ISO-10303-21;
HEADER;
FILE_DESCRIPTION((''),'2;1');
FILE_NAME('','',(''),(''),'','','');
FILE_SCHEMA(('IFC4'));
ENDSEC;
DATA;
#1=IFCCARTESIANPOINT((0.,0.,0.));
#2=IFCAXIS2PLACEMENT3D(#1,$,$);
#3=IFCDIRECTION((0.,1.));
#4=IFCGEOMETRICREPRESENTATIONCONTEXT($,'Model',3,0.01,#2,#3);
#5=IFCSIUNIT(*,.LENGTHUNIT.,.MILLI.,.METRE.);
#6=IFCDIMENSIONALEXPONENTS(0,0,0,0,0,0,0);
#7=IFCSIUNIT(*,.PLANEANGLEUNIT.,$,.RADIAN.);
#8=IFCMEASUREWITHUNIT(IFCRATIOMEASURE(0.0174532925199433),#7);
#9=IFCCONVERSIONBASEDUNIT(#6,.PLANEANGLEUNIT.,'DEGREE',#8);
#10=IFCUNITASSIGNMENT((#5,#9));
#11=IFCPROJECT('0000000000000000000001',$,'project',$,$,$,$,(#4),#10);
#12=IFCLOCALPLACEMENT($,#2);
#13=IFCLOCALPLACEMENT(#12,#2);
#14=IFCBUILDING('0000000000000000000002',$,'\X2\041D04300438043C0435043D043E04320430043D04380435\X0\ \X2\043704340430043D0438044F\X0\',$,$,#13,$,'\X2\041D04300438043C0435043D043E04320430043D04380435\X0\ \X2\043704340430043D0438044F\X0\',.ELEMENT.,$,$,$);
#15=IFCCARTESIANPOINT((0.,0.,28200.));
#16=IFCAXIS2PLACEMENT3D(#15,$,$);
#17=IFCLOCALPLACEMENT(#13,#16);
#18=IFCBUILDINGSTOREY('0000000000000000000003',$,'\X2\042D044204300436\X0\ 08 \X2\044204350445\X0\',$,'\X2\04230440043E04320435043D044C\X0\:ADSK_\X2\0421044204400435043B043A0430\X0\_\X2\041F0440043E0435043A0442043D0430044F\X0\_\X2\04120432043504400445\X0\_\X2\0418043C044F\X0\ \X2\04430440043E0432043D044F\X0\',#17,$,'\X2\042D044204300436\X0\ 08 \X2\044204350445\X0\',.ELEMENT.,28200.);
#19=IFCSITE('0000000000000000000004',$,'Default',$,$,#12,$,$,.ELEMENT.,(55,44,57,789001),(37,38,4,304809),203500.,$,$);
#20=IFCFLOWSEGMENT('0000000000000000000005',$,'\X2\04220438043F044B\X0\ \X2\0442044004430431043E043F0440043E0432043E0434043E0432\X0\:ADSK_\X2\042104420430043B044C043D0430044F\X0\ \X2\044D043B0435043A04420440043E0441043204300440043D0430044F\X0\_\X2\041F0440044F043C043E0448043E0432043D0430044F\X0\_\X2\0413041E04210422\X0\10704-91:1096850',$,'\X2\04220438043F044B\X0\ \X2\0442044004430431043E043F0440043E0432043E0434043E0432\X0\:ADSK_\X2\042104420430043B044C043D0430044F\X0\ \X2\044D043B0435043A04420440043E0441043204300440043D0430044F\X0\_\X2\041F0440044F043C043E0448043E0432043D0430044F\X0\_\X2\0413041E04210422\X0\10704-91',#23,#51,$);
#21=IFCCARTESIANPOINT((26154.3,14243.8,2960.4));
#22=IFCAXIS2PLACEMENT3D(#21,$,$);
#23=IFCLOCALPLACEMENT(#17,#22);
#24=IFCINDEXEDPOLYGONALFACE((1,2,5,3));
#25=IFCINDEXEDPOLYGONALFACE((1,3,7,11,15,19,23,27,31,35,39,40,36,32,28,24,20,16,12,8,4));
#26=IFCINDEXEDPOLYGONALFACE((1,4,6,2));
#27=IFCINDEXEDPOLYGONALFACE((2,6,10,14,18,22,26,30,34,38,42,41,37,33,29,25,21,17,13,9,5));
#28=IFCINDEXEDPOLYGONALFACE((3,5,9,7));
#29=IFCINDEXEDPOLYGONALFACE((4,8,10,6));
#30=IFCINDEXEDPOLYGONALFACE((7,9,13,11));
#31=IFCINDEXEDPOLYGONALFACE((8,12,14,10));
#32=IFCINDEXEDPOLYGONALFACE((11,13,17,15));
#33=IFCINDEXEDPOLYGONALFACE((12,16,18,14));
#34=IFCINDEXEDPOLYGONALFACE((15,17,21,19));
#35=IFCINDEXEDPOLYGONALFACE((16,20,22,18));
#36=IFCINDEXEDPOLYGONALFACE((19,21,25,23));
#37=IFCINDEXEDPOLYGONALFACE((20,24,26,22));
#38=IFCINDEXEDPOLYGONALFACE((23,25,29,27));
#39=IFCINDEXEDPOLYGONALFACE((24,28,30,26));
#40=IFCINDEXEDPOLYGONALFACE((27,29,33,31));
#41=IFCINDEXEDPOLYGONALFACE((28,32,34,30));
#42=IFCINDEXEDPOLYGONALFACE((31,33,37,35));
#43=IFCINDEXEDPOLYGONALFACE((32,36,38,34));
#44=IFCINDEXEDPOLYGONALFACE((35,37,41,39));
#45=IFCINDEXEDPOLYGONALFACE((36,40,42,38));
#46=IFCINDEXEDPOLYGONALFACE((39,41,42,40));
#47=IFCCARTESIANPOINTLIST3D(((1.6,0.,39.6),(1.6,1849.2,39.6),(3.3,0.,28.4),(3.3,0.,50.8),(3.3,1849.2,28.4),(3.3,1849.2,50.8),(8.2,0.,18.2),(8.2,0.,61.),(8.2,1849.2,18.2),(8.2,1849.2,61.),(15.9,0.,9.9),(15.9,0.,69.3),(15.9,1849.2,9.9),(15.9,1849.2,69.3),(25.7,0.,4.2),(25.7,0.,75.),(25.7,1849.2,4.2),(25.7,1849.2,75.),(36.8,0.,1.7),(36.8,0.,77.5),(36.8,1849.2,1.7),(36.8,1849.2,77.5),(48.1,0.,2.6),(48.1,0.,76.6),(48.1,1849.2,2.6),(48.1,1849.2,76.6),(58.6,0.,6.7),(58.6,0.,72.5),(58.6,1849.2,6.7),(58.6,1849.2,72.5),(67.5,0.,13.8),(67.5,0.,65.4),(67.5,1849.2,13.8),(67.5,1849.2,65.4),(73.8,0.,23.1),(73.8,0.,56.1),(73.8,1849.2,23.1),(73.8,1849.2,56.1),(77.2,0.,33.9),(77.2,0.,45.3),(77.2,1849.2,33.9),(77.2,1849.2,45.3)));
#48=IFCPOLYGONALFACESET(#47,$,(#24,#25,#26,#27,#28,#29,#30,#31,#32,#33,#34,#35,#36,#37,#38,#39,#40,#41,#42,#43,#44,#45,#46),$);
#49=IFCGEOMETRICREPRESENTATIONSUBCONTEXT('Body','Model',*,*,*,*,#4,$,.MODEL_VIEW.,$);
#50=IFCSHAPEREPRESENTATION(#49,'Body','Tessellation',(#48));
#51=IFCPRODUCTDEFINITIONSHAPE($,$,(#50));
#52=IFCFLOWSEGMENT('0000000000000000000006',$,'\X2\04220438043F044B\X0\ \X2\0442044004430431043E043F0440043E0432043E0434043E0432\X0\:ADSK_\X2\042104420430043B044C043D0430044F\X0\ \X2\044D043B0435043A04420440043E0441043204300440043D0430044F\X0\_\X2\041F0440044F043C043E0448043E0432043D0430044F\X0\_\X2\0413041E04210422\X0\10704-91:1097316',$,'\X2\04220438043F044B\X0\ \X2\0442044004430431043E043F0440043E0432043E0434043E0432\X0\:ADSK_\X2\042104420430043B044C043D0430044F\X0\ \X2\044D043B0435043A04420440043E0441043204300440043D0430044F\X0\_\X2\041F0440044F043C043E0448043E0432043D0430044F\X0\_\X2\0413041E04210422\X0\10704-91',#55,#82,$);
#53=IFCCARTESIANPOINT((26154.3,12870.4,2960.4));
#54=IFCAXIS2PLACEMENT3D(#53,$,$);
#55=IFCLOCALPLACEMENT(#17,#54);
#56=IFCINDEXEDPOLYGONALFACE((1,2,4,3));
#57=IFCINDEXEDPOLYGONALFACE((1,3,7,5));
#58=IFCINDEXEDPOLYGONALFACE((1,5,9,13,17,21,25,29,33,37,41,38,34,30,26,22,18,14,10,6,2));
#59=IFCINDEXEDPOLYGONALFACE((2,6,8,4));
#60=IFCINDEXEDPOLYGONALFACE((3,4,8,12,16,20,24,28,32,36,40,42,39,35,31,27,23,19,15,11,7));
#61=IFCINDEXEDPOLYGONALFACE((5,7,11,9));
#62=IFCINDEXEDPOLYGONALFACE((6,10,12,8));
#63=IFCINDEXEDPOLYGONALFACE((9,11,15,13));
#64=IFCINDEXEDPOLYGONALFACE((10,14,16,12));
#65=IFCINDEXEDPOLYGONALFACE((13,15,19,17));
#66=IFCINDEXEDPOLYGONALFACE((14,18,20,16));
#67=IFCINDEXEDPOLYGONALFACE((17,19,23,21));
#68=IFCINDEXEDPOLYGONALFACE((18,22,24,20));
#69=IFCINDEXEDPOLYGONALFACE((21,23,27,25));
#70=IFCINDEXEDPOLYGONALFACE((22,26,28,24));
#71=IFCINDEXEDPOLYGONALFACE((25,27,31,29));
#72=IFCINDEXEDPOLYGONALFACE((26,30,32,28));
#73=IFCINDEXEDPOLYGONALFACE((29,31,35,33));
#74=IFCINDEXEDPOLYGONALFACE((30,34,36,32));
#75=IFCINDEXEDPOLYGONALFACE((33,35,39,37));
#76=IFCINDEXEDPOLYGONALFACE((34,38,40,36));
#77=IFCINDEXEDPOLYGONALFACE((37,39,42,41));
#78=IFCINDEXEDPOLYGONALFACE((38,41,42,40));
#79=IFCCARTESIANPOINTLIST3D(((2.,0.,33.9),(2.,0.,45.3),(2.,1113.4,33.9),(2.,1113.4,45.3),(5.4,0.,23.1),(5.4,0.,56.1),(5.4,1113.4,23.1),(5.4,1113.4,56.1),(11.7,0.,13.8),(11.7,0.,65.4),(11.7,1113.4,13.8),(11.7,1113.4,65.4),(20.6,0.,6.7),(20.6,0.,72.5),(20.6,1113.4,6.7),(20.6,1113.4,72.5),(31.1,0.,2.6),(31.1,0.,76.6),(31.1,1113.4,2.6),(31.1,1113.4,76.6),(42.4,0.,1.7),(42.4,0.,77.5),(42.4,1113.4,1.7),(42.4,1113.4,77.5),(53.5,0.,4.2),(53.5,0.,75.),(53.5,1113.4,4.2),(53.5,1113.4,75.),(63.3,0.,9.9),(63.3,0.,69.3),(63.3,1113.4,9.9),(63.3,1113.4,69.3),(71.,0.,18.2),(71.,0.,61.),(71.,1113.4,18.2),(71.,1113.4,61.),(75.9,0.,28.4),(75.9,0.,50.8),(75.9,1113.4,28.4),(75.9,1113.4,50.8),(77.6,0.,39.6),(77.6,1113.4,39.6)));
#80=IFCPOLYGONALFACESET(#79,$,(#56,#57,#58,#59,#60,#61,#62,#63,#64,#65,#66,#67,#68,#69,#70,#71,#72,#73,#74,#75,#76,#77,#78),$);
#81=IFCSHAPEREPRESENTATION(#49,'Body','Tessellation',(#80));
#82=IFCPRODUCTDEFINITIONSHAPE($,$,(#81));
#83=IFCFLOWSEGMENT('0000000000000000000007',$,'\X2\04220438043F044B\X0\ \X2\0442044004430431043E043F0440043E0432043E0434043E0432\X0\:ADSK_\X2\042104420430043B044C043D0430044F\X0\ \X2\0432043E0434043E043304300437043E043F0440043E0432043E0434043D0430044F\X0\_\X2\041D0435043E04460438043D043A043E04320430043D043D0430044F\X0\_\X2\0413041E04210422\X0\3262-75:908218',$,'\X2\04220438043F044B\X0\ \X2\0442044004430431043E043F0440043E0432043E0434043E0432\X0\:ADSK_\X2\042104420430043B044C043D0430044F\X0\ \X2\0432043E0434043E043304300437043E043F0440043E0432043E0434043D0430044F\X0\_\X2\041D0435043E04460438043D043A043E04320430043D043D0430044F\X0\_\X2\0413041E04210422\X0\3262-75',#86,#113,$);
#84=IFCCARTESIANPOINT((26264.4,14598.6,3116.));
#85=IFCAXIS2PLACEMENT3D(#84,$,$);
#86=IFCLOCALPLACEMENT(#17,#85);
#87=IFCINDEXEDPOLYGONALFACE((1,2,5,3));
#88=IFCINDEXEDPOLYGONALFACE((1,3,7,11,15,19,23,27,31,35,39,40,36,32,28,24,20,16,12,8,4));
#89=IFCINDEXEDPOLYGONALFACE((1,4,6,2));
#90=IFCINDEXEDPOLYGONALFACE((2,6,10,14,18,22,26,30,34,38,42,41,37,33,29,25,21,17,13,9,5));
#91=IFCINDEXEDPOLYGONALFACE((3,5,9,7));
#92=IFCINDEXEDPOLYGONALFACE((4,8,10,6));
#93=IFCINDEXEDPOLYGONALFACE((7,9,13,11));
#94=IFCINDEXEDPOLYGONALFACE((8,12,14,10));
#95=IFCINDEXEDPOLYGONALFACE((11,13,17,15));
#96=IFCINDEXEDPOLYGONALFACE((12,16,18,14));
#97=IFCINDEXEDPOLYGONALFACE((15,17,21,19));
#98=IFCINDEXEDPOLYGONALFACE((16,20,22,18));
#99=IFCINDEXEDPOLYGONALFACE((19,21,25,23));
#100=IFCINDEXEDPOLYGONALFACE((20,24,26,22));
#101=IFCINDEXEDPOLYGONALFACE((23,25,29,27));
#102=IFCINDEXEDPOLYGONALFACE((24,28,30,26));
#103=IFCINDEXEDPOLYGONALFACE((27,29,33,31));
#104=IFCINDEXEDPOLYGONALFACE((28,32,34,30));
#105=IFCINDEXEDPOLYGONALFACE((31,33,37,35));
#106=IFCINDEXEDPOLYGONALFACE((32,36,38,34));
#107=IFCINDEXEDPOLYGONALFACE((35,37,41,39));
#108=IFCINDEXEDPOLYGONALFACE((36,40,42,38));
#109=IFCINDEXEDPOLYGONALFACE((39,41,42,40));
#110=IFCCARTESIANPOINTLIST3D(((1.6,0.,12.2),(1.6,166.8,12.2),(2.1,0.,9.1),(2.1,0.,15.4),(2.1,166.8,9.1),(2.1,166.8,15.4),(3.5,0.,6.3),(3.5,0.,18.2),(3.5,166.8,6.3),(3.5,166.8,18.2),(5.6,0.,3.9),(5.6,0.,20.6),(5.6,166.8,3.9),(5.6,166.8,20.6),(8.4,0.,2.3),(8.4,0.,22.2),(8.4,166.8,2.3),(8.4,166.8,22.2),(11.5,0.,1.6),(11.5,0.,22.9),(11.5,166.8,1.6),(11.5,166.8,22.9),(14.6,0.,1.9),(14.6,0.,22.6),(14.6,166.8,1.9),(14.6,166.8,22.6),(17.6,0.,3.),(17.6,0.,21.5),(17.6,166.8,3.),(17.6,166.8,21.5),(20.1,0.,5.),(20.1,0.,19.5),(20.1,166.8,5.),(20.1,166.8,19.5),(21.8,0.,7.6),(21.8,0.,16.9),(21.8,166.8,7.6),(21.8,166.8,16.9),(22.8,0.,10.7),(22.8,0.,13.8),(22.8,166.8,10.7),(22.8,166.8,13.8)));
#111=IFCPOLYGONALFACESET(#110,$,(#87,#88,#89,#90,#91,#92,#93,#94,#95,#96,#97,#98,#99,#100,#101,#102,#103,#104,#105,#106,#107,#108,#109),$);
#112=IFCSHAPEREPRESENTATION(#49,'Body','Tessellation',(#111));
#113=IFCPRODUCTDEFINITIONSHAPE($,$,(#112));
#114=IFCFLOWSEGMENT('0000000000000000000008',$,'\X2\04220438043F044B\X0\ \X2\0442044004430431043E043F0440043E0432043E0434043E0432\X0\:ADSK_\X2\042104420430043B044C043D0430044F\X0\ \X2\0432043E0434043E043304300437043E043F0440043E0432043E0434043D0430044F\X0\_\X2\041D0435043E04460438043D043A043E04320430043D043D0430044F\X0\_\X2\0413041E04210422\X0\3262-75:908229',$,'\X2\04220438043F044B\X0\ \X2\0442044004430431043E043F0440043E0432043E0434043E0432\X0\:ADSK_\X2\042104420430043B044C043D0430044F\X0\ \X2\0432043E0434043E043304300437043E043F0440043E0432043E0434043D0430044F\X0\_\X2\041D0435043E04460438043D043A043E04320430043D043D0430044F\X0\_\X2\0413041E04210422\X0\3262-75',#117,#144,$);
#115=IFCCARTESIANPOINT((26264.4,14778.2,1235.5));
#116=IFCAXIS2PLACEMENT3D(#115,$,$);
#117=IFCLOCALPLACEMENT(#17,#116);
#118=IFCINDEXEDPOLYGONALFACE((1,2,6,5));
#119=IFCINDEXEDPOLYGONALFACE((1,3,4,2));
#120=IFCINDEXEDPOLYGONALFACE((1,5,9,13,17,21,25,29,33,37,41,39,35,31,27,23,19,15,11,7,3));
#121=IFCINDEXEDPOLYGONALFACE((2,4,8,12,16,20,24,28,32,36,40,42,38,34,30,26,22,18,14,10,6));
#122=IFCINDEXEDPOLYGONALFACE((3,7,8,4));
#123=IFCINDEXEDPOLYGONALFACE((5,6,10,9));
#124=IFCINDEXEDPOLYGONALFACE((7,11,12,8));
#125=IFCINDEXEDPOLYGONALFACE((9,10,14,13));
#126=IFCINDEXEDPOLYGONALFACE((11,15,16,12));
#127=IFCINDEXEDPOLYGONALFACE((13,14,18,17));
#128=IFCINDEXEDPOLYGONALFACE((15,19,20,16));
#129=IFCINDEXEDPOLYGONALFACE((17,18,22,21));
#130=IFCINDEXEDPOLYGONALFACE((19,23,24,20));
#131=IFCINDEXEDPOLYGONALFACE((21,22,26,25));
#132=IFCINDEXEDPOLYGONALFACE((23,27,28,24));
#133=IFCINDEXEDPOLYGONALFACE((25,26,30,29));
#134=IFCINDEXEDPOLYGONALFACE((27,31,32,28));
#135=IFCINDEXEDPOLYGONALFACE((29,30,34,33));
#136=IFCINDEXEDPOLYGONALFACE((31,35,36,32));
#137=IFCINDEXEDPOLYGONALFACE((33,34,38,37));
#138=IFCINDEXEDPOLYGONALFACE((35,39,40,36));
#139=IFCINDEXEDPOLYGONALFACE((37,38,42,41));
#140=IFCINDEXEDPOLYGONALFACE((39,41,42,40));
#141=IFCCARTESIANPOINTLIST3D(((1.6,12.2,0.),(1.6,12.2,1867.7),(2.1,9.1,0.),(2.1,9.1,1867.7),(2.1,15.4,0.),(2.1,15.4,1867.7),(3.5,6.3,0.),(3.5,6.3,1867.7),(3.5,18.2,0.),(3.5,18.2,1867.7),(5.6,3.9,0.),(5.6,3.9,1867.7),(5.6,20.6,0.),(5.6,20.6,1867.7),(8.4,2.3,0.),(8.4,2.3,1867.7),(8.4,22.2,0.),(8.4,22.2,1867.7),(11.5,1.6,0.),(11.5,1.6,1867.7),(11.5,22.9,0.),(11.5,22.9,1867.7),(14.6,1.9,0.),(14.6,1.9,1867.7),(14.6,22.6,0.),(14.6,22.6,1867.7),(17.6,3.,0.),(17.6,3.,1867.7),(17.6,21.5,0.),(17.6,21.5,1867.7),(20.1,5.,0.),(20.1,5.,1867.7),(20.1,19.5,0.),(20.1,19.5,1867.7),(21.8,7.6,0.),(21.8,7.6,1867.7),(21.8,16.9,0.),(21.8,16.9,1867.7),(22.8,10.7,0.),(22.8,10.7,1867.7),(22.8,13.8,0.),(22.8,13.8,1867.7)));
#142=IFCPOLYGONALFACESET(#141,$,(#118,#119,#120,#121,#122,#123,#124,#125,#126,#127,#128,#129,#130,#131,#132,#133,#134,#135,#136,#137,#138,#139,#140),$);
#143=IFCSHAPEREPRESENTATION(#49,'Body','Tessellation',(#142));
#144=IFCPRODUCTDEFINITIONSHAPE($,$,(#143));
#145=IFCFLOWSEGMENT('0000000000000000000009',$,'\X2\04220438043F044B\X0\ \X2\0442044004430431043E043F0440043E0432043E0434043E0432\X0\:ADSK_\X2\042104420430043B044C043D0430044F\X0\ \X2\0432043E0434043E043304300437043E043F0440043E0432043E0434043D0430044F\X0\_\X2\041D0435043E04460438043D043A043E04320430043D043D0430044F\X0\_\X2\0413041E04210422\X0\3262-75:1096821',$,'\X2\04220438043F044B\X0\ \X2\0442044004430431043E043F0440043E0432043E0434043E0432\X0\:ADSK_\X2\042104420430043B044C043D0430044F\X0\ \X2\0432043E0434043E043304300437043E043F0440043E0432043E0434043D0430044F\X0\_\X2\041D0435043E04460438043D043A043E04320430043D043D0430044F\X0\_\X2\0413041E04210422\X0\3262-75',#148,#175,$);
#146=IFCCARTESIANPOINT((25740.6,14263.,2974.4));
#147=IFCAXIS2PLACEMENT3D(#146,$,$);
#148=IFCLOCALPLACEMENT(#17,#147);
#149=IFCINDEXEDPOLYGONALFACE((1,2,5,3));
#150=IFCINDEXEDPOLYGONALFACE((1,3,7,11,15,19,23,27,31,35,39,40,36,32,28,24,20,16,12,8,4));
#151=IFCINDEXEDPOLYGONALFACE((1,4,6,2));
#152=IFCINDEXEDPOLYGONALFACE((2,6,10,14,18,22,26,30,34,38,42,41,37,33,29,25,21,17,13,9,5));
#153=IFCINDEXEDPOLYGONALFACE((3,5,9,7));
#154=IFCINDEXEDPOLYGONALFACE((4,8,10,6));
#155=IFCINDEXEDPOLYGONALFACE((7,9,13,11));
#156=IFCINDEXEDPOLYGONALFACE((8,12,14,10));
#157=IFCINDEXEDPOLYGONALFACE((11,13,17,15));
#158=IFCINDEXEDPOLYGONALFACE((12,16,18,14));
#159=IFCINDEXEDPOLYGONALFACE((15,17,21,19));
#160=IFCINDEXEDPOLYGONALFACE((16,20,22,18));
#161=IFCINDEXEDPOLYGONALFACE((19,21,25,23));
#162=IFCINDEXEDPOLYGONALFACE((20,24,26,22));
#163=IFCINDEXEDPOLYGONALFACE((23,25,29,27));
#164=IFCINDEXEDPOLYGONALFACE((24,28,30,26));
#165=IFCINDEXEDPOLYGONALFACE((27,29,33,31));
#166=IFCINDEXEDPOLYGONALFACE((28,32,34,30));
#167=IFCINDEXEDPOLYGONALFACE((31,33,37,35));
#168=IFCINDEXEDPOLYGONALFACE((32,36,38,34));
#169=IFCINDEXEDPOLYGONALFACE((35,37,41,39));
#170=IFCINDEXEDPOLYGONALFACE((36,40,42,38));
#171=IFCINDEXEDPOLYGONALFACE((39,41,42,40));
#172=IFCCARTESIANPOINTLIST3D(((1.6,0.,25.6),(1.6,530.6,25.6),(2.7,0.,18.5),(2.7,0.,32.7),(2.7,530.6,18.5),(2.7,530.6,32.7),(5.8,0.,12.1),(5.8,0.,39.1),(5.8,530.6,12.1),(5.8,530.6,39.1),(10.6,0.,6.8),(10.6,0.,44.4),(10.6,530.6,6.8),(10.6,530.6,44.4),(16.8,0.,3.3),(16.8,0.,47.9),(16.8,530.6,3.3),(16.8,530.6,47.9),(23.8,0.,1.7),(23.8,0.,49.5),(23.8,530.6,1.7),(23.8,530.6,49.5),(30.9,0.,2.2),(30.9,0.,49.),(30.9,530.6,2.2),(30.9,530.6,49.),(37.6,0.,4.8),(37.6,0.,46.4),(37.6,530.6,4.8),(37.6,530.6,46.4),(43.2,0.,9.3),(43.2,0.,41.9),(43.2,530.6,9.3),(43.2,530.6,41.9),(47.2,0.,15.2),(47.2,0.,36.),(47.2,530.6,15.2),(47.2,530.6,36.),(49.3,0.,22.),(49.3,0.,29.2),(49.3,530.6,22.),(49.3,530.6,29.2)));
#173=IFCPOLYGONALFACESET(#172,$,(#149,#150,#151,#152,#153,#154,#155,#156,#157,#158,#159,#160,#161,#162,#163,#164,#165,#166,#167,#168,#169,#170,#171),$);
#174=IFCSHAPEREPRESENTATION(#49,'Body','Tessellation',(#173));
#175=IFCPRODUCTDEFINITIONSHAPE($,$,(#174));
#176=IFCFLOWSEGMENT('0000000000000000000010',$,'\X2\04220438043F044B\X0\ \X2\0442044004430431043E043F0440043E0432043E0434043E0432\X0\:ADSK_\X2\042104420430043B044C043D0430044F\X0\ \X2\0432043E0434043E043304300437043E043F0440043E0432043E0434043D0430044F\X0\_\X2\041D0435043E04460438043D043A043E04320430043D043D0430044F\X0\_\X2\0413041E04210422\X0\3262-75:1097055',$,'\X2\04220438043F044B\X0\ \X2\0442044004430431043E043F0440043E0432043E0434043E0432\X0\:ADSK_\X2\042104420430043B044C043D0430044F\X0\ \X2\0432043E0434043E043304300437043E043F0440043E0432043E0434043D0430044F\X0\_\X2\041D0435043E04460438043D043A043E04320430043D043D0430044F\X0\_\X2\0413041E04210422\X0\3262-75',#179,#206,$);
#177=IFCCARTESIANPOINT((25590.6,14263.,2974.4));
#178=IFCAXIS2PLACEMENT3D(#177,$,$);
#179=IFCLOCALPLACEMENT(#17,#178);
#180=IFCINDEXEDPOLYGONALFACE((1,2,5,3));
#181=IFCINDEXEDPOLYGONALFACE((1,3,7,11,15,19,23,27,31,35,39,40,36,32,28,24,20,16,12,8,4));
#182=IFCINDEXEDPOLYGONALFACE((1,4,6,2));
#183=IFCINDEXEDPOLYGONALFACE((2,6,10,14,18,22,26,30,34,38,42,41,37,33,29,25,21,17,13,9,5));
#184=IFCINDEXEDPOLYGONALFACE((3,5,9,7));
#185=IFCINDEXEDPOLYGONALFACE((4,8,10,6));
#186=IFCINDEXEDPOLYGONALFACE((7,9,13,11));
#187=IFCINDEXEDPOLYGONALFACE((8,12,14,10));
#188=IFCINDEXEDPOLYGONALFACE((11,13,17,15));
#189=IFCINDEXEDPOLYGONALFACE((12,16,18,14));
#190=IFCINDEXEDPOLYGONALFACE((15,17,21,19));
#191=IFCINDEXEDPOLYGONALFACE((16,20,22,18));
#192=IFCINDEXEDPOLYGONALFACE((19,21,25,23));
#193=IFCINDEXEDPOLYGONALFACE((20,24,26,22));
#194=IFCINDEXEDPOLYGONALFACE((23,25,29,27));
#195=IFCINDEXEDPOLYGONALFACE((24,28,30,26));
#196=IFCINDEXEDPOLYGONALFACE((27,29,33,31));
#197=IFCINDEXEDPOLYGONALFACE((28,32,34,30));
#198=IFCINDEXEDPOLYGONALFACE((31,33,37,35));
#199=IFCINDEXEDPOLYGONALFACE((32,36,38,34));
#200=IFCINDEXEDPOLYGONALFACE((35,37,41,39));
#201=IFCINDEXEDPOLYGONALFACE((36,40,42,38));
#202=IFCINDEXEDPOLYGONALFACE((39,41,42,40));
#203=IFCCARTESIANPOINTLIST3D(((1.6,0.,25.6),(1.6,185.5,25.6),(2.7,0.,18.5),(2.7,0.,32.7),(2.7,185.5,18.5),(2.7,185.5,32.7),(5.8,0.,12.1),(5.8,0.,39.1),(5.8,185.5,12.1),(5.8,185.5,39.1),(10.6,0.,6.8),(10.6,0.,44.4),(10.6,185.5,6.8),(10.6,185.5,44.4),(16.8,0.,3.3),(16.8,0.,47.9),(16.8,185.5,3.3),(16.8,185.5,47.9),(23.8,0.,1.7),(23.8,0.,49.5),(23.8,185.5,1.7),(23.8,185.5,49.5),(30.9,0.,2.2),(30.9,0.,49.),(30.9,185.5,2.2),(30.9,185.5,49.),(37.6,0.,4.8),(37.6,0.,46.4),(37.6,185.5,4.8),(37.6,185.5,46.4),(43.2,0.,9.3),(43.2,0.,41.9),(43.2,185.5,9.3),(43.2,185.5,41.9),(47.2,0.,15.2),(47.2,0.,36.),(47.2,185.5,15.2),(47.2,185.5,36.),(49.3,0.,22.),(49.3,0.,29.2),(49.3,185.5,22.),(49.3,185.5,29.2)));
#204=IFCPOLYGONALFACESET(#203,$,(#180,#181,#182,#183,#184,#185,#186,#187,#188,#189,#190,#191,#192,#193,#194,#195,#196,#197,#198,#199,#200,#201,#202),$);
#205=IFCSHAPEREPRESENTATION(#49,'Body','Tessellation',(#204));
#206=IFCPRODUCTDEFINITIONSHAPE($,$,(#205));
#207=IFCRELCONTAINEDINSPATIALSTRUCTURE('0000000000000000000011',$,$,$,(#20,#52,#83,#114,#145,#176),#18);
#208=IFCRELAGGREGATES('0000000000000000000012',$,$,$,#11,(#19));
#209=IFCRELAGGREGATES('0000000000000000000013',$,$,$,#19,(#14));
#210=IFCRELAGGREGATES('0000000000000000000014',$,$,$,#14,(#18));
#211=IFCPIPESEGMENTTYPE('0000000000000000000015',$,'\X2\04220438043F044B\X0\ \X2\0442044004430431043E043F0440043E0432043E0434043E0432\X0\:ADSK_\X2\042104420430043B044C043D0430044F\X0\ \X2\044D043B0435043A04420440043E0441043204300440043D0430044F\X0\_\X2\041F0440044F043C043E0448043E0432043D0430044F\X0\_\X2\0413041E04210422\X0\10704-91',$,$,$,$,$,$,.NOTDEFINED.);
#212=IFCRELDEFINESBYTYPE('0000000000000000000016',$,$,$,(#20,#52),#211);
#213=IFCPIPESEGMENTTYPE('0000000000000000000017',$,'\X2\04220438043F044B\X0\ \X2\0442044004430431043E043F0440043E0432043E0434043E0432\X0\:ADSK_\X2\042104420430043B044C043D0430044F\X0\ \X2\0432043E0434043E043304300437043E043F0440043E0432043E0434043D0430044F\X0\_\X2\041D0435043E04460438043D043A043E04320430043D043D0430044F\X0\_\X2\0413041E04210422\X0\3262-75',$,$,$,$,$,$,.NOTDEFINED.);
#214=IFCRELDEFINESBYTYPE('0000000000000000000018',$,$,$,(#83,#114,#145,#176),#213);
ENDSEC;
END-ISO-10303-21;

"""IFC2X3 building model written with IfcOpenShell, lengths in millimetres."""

from ifc_helpers import new_model, entity, si_unit, converted_unit, direction, frame, origin, origin_2d_with_axis, place, context, subcontext, project, spatial, circle, extrude, type_object, element, save


model = new_model("IFC2X3")

# Units and contexts
model_context = context("Model", 3, precision=0.01, world=origin(), true_north=direction((0.0, 1.0)))
body_context = subcontext(model_context, "Body", "Model", "MODEL_VIEW")
ifc_project = project(units=[si_unit("LENGTHUNIT", "METRE", prefix="MILLI"), converted_unit("PLANEANGLEUNIT", "DEGREE", entity("IfcRatioMeasure", 0.0174532925199433), si_unit("PLANEANGLEUNIT", "RADIAN"), dimensions=[0, 0, 0, 0, 0, 0, 0])], contexts=[model_context])

# Site, building, storey
site_placement = place(None, origin())
site = spatial("IfcSite", under=ifc_project, at=site_placement, Name="Default", CompositionType="ELEMENT", RefLatitude=(55, 44, 57, 789001), RefLongitude=(37, 38, 4, 304809), RefElevation=203500.0)
building_placement = place(site_placement, origin())
building = spatial("IfcBuilding", under=site, at=building_placement, Name="Наименование здания", LongName="Наименование здания", CompositionType="ELEMENT")
storey_placement = place(building_placement, frame((0.0, 0.0, 28200.0)))
storey = spatial("IfcBuildingStorey", under=building, at=storey_placement, Name="Этаж 08 тех", ObjectType="Уровень:ADSK_Стрелка_Проектная_Вверх_Имя уровня", LongName="Этаж 08 тех", CompositionType="ELEMENT", Elevation=28200.0)

# Flow segments
pipe_segment_type_1 = type_object("IfcPipeSegmentType", Name="Типы трубопроводов:ADSK_Стальная электросварная_Прямошовная_ГОСТ10704-91", PredefinedType="NOTDEFINED")
flow_segment_1_placement = place(storey_placement, frame((26154.3, 14243.8, 2960.4)))
element("IfcFlowSegment", 1, at=flow_segment_1_placement, inside=storey, type_object=pipe_segment_type_1, Name="Типы трубопроводов:ADSK_Стальная электросварная_Прямошовная_ГОСТ10704-91:1096850", ObjectType="Типы трубопроводов:ADSK_Стальная электросварная_Прямошовная_ГОСТ10704-91", context=body_context, shape_type="SweptSolid", body=[
    extrude(circle(Radius=38.0, at=origin_2d_with_axis()), frame((39.6, 0.0, 39.6), z_axis=(0.0, 1.0, 0.0), x_axis=(-1.0, 0.0, 0.0)), (0.0, 0.0, 1.0), 1849.2),
])
flow_segment_2_placement = place(storey_placement, frame((26154.3, 12870.4, 2960.4)))
element("IfcFlowSegment", 2, at=flow_segment_2_placement, inside=storey, type_object=pipe_segment_type_1, Name="Типы трубопроводов:ADSK_Стальная электросварная_Прямошовная_ГОСТ10704-91:1097316", ObjectType="Типы трубопроводов:ADSK_Стальная электросварная_Прямошовная_ГОСТ10704-91", context=body_context, shape_type="SweptSolid", body=[
    extrude(circle(Radius=38.0, at=origin_2d_with_axis()), frame((39.6, 0.0, 39.6), z_axis=(0.0, 1.0, 0.0), x_axis=(1.0, 0.0, 0.0)), (0.0, 0.0, 1.0), 1113.4),
])
pipe_segment_type_2 = type_object("IfcPipeSegmentType", Name="Типы трубопроводов:ADSK_Стальная водогазопроводная_Неоцинкованная_ГОСТ3262-75", PredefinedType="NOTDEFINED")
flow_segment_3_placement = place(storey_placement, frame((26264.4, 14598.6, 3116.0)))
element("IfcFlowSegment", 3, at=flow_segment_3_placement, inside=storey, type_object=pipe_segment_type_2, Name="Типы трубопроводов:ADSK_Стальная водогазопроводная_Неоцинкованная_ГОСТ3262-75:908218", ObjectType="Типы трубопроводов:ADSK_Стальная водогазопроводная_Неоцинкованная_ГОСТ3262-75", context=body_context, shape_type="SweptSolid", body=[
    extrude(circle(Radius=10.7, at=origin_2d_with_axis()), frame((12.2, 0.0, 12.2), z_axis=(0.0, 1.0, 0.0), x_axis=(-1.0, 0.0, 0.0)), (0.0, 0.0, 1.0), 166.8),
])
flow_segment_4_placement = place(storey_placement, frame((26264.4, 14778.2, 1235.5)))
element("IfcFlowSegment", 4, at=flow_segment_4_placement, inside=storey, type_object=pipe_segment_type_2, Name="Типы трубопроводов:ADSK_Стальная водогазопроводная_Неоцинкованная_ГОСТ3262-75:908229", ObjectType="Типы трубопроводов:ADSK_Стальная водогазопроводная_Неоцинкованная_ГОСТ3262-75", context=body_context, shape_type="SweptSolid", body=[
    extrude(circle(Radius=10.7, at=origin_2d_with_axis()), frame((12.2, 12.2, 0.0), z_axis=(0.0, 0.0, 1.0), x_axis=(-1.0, 0.0, 0.0)), (0.0, 0.0, 1.0), 1867.7),
])
flow_segment_5_placement = place(storey_placement, frame((25740.6, 14263.0, 2974.4)))
element("IfcFlowSegment", 5, at=flow_segment_5_placement, inside=storey, type_object=pipe_segment_type_2, Name="Типы трубопроводов:ADSK_Стальная водогазопроводная_Неоцинкованная_ГОСТ3262-75:1096821", ObjectType="Типы трубопроводов:ADSK_Стальная водогазопроводная_Неоцинкованная_ГОСТ3262-75", context=body_context, shape_type="SweptSolid", body=[
    extrude(circle(Radius=24.0, at=origin_2d_with_axis()), frame((25.6, 0.0, 25.6), z_axis=(0.0, 1.0, 0.0), x_axis=(-1.0, 0.0, 0.0)), (0.0, 0.0, 1.0), 530.6),
])
flow_segment_6_placement = place(storey_placement, frame((25590.6, 14263.0, 2974.4)))
element("IfcFlowSegment", 6, at=flow_segment_6_placement, inside=storey, type_object=pipe_segment_type_2, Name="Типы трубопроводов:ADSK_Стальная водогазопроводная_Неоцинкованная_ГОСТ3262-75:1097055", ObjectType="Типы трубопроводов:ADSK_Стальная водогазопроводная_Неоцинкованная_ГОСТ3262-75", context=body_context, shape_type="SweptSolid", body=[
    extrude(circle(Radius=24.0, at=origin_2d_with_axis()), frame((25.6, 0.0, 25.6), z_axis=(0.0, 1.0, 0.0), x_axis=(-1.0, 0.0, 0.0)), (0.0, 0.0, 1.0), 185.5),
])

save(model, "model.ifc")
